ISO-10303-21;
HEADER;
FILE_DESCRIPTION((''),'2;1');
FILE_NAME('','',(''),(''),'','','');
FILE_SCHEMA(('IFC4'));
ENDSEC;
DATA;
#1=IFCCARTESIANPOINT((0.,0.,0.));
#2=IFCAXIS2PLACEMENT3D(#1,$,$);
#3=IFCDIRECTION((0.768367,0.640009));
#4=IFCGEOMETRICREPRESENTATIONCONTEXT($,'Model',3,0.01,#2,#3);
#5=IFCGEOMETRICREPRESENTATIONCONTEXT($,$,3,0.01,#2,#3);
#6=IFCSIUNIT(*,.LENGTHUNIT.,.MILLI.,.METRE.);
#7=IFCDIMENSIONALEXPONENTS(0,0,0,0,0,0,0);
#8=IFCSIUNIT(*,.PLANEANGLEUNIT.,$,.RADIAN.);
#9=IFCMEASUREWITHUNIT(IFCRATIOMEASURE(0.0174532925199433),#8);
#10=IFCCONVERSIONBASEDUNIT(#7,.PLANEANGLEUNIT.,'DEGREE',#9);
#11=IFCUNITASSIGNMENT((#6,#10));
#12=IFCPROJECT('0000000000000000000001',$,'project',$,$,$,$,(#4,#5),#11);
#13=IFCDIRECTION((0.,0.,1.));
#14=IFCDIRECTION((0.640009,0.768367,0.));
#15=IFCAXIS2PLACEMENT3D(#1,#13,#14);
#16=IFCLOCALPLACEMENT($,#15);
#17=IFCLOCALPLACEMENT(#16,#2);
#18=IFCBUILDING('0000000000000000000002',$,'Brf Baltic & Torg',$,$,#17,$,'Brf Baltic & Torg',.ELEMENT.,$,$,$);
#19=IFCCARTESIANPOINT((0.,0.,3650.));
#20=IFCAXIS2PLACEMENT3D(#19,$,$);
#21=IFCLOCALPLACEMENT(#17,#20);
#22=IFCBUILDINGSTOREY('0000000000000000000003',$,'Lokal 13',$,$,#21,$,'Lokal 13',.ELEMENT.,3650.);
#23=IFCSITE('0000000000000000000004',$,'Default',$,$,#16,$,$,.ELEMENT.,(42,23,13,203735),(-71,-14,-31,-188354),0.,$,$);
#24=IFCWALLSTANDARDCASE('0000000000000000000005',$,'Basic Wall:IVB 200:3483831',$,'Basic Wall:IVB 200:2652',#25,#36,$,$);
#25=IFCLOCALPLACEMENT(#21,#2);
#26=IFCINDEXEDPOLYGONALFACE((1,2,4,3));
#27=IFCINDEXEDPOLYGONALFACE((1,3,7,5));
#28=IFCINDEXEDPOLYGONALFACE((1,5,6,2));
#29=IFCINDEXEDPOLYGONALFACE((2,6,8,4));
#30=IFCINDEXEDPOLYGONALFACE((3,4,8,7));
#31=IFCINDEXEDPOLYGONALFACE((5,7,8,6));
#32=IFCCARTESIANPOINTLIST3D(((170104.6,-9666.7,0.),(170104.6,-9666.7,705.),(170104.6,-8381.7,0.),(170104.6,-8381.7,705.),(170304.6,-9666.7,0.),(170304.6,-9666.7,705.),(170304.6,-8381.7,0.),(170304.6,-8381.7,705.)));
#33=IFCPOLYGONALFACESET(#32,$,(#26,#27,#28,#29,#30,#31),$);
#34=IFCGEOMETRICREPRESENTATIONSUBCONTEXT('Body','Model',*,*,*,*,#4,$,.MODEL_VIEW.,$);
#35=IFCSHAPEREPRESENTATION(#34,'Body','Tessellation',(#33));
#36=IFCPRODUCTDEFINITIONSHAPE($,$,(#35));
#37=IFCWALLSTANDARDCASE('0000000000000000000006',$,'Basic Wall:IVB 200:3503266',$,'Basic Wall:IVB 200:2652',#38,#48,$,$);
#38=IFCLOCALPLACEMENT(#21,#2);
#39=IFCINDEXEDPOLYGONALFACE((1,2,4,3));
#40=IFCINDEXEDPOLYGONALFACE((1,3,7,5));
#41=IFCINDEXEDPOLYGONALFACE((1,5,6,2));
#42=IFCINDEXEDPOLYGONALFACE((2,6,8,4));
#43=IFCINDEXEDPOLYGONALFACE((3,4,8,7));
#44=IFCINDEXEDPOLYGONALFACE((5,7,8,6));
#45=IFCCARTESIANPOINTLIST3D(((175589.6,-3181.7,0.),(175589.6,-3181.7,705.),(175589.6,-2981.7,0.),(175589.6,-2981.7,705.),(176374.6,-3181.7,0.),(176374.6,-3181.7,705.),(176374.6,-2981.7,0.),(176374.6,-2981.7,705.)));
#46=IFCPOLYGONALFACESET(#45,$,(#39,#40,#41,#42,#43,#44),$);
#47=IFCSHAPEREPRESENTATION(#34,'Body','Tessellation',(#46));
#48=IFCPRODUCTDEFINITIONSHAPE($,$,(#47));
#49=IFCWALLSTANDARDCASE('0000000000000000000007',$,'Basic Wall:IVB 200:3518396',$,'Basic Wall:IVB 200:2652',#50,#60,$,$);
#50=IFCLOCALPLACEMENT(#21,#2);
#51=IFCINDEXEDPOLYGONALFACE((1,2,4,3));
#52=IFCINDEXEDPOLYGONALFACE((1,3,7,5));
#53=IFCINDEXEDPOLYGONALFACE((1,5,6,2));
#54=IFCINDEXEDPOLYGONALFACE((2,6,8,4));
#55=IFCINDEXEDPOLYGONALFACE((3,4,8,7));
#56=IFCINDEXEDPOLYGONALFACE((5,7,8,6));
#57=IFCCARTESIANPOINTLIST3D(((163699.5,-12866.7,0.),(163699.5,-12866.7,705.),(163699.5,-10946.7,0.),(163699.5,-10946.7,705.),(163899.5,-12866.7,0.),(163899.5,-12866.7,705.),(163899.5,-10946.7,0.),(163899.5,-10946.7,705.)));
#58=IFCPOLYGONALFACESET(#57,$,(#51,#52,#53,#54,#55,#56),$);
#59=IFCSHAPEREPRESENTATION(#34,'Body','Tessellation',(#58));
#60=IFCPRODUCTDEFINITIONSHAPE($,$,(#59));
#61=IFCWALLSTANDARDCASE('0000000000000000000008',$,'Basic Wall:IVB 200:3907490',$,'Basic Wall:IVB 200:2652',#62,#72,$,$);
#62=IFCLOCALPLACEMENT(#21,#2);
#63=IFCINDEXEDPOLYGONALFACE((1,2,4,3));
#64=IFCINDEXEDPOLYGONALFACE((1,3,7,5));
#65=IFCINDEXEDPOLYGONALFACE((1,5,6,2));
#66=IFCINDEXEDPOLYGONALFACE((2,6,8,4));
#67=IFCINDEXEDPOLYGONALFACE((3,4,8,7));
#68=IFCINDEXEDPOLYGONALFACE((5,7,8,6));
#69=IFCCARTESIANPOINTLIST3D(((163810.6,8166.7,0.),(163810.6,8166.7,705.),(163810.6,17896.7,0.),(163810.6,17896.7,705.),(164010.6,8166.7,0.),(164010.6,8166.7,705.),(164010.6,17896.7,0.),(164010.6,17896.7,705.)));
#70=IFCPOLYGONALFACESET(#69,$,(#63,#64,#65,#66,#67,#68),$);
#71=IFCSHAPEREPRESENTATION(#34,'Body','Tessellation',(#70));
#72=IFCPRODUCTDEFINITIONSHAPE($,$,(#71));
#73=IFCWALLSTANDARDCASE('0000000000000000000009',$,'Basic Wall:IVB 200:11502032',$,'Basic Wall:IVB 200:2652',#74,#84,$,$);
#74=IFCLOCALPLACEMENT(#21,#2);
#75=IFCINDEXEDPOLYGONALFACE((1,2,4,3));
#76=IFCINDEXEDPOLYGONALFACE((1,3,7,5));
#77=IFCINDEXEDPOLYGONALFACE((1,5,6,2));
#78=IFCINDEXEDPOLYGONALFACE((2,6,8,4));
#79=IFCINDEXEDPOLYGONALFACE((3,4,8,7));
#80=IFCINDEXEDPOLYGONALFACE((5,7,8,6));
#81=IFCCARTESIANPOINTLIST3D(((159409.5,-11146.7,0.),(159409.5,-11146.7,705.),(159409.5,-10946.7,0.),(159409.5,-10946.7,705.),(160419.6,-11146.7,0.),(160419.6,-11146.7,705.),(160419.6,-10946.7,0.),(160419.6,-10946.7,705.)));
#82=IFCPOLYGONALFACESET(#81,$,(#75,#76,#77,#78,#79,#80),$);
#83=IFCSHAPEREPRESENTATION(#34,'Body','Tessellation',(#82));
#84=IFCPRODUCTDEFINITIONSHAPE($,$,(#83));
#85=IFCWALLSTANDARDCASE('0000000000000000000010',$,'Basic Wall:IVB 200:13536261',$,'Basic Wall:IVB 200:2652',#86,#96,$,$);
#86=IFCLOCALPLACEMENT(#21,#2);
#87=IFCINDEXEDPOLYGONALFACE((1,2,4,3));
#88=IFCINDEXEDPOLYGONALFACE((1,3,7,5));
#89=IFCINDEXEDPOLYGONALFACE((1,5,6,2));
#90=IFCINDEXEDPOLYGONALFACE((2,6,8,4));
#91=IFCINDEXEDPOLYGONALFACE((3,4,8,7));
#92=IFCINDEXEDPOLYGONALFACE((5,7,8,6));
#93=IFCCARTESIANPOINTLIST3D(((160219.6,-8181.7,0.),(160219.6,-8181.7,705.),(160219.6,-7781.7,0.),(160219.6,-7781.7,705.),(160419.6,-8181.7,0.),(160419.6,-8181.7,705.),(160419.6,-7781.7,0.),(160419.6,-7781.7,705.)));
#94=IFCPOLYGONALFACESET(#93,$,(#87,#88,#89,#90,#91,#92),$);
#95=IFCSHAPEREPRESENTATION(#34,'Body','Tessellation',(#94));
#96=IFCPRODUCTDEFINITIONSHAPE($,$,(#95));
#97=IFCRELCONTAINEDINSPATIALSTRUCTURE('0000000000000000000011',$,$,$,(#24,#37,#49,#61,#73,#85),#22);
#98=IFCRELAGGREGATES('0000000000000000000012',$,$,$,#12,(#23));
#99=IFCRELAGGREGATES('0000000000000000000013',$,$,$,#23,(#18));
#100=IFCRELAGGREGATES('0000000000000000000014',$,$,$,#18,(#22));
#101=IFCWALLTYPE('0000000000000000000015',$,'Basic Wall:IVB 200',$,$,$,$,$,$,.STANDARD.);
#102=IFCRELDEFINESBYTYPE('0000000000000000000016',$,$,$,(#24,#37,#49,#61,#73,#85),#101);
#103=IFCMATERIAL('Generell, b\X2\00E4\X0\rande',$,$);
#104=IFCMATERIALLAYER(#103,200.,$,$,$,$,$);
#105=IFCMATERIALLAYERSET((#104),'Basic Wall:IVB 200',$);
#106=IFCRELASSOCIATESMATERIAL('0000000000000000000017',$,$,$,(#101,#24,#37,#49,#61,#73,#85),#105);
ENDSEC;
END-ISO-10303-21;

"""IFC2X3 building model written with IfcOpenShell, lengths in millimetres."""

from ifc_helpers import new_model, entity, si_unit, converted_unit, direction, frame, frame_2d, origin, place, context, subcontext, project, spatial, polyline, rectangle, extrude, clip, halfspace, bounded_halfspace, material, layer, layer_set, layer_usage, type_object, element, save


model = new_model("IFC2X3")

# Units and contexts
model_context = context("Model", 3, precision=0.01, world=origin(), true_north=direction((0.768367, 0.640009)))
context_of_model = context(None, 3, precision=0.01, world=origin(), true_north=direction((0.768367, 0.640009)))
body_context = subcontext(model_context, "Body", "Model", "MODEL_VIEW")
ifc_project = project(units=[si_unit("LENGTHUNIT", "METRE", prefix="MILLI"), converted_unit("PLANEANGLEUNIT", "DEGREE", entity("IfcRatioMeasure", 0.0174532925199433), si_unit("PLANEANGLEUNIT", "RADIAN"), dimensions=[0, 0, 0, 0, 0, 0, 0])], contexts=[model_context, context_of_model])

# Site, building, storey
site_placement = place(None, frame((0.0, 0.0, 0.0), z_axis=(0.0, 0.0, 1.0), x_axis=(0.640009, 0.768367, 0.0)))
site = spatial("IfcSite", under=ifc_project, at=site_placement, Name="Default", CompositionType="ELEMENT", RefLatitude=(42, 23, 13, 203735), RefLongitude=(-71, -14, -31, -188354), RefElevation=0.0)
building_placement = place(site_placement, origin())
building = spatial("IfcBuilding", under=site, at=building_placement, Name="Brf Baltic & Torg", LongName="Brf Baltic & Torg", CompositionType="ELEMENT")
storey_placement = place(building_placement, frame((0.0, 0.0, 3650.0)))
storey = spatial("IfcBuildingStorey", under=building, at=storey_placement, Name="Lokal 13", LongName="Lokal 13", CompositionType="ELEMENT", Elevation=3650.0)

# Walls
ifc_material_1 = material(Name="Generell, bärande")
ifc_layer = layer(ifc_material_1, 200.0)
ifc_layer_set = layer_set([ifc_layer], Name="Basic Wall:IVB 200")
wall_type = type_object("IfcWallType", Name="Basic Wall:IVB 200", PredefinedType="STANDARD", material=ifc_layer_set)
ifc_layer_usage_1 = layer_usage(ifc_layer_set, "AXIS2", "POSITIVE", -100.0)
wall_1_placement = place(storey_placement, frame((170204.6, -8381.7, 0.0), z_axis=(0.0, 0.0, 1.0), x_axis=(0.0, -1.0, 0.0)))
element("IfcWallStandardCase", 1, at=wall_1_placement, inside=storey, type_object=wall_type, material=ifc_layer_usage_1, Name="Basic Wall:IVB 200:3483831", ObjectType="Basic Wall:IVB 200:2652", context=body_context, shape_type="Clipping", body=[
    clip(clip(extrude(rectangle(XDim=1285.0, YDim=200.0, at=frame_2d((642.5, 0.0), x_axis=(-1.0, 0.0))), origin(), (0.0, 0.0, 1.0), 705.0), bounded_halfspace(frame((0.0, -100.0, 705.0), z_axis=(0.0, 0.0, -1.0), x_axis=(-1.0, 0.0, 0.0)), True, frame((0.0, -100.0, 705.0)), polyline([(0.0, 0.0), (1285.0, 0.0), (1285.0, 200.0), (0.0, 200.0), (0.0, 0.0)]))), halfspace(frame((0.0, 0.0, -2000.0)), True)),
])
ifc_layer_usage_2 = layer_usage(ifc_layer_set, "AXIS2", "NEGATIVE", 100.0)
wall_2_placement = place(storey_placement, frame((175589.6, -3081.7, 0.0)))
element("IfcWallStandardCase", 2, at=wall_2_placement, inside=storey, type_object=wall_type, material=ifc_layer_usage_2, Name="Basic Wall:IVB 200:3503266", ObjectType="Basic Wall:IVB 200:2652", context=body_context, shape_type="Clipping", body=[
    clip(clip(extrude(rectangle(XDim=785.0, YDim=200.0, at=frame_2d((392.5, 0.0), x_axis=(-1.0, 0.0))), origin(), (0.0, 0.0, 1.0), 705.0), bounded_halfspace(frame((0.0, -100.0, 705.0), z_axis=(0.0, 0.0, -1.0), x_axis=(0.0, 1.0, 0.0)), True, frame((0.0, -100.0, 705.0)), polyline([(0.0, 0.0), (585.0, 0.0), (785.0, 0.0), (785.0, 200.0), (0.0, 200.0), (0.0, 0.0)]))), halfspace(frame((0.0, 0.0, -2000.0)), True)),
])
ifc_layer_usage_3 = layer_usage(ifc_layer_set, "AXIS2", "POSITIVE", -100.0)
wall_3_placement = place(storey_placement, frame((163799.5, -10946.7, 0.0), z_axis=(0.0, 0.0, 1.0), x_axis=(0.0, -1.0, 0.0)))
element("IfcWallStandardCase", 3, at=wall_3_placement, inside=storey, type_object=wall_type, material=ifc_layer_usage_3, Name="Basic Wall:IVB 200:3518396", ObjectType="Basic Wall:IVB 200:2652", context=body_context, shape_type="Clipping", body=[
    clip(clip(extrude(rectangle(XDim=1920.0, YDim=200.0, at=frame_2d((960.0, 0.0), x_axis=(-1.0, 0.0))), origin(), (0.0, 0.0, 1.0), 705.0), bounded_halfspace(frame((0.0, -100.0, 705.0), z_axis=(0.0, 0.0, -1.0), x_axis=(-1.0, 0.0, 0.0)), True, frame((0.0, -100.0, 705.0)), polyline([(0.0, 0.0), (1920.0, 0.0), (1920.0, 200.0), (0.0, 200.0), (0.0, 0.0)]))), halfspace(frame((0.0, 0.0, -2000.0)), True)),
])

# Walls
ifc_layer_usage_4 = layer_usage(ifc_layer_set, "AXIS2", "NEGATIVE", 100.0)
wall_4_placement = place(storey_placement, frame((163910.6, 8166.7, 0.0), z_axis=(0.0, 0.0, 1.0), x_axis=(0.0, 1.0, 0.0)))
element("IfcWallStandardCase", 4, at=wall_4_placement, inside=storey, type_object=wall_type, material=ifc_layer_usage_4, Name="Basic Wall:IVB 200:3907490", ObjectType="Basic Wall:IVB 200:2652", context=body_context, shape_type="Clipping", body=[
    clip(clip(extrude(rectangle(XDim=9730.0, YDim=200.0, at=frame_2d((4865.0, 0.0), x_axis=(-1.0, 0.0))), origin(), (0.0, 0.0, 1.0), 705.0), bounded_halfspace(frame((0.0, -100.0, 705.0), z_axis=(0.0, 0.0, -1.0), x_axis=(1.0, 0.0, 0.0)), True, frame((0.0, -100.0, 705.0)), polyline([(0.0, 0.0), (200.0, 0.0), (9530.0, 0.0), (9730.0, 0.0), (9730.0, 200.0), (0.0, 200.0), (0.0, 0.0)]))), halfspace(frame((0.0, 0.0, -2000.0)), True)),
])
ifc_layer_usage_5 = layer_usage(ifc_layer_set, "AXIS2", "NEGATIVE", 100.0)
wall_5_placement = place(storey_placement, frame((159409.5, -11046.7, 0.0)))
element("IfcWallStandardCase", 5, at=wall_5_placement, inside=storey, type_object=wall_type, material=ifc_layer_usage_5, Name="Basic Wall:IVB 200:11502032", ObjectType="Basic Wall:IVB 200:2652", context=body_context, shape_type="Clipping", body=[
    clip(clip(extrude(rectangle(XDim=1010.1, YDim=200.0, at=frame_2d((505.0, 0.0), x_axis=(-1.0, 0.0))), origin(), (0.0, 0.0, 1.0), 705.0), bounded_halfspace(frame((0.0, -100.0, 705.0), z_axis=(0.0, 0.0, -1.0), x_axis=(0.0, 1.0, 0.0)), True, frame((0.0, -100.0, 705.0)), polyline([(0.0, 0.0), (1010.1, 0.0), (1010.1, 200.0), (0.0, 200.0), (0.0, 0.0)]))), halfspace(frame((0.0, 0.0, -2000.0)), True)),
])
ifc_layer_usage_6 = layer_usage(ifc_layer_set, "AXIS2", "NEGATIVE", 100.0)
wall_6_placement = place(storey_placement, frame((160319.6, -8181.7, 0.0), z_axis=(0.0, 0.0, 1.0), x_axis=(0.0, 1.0, 0.0)))
element("IfcWallStandardCase", 6, at=wall_6_placement, inside=storey, type_object=wall_type, material=ifc_layer_usage_6, Name="Basic Wall:IVB 200:13536261", ObjectType="Basic Wall:IVB 200:2652", context=body_context, shape_type="Clipping", body=[
    clip(extrude(rectangle(XDim=400.0, YDim=200.0, at=frame_2d((200.0, 0.0), x_axis=(-1.0, 0.0))), origin(), (0.0, 0.0, 1.0), 705.0), halfspace(frame((0.0, 0.0, -2000.0)), True)),
])

save(model, "model.ifc")
